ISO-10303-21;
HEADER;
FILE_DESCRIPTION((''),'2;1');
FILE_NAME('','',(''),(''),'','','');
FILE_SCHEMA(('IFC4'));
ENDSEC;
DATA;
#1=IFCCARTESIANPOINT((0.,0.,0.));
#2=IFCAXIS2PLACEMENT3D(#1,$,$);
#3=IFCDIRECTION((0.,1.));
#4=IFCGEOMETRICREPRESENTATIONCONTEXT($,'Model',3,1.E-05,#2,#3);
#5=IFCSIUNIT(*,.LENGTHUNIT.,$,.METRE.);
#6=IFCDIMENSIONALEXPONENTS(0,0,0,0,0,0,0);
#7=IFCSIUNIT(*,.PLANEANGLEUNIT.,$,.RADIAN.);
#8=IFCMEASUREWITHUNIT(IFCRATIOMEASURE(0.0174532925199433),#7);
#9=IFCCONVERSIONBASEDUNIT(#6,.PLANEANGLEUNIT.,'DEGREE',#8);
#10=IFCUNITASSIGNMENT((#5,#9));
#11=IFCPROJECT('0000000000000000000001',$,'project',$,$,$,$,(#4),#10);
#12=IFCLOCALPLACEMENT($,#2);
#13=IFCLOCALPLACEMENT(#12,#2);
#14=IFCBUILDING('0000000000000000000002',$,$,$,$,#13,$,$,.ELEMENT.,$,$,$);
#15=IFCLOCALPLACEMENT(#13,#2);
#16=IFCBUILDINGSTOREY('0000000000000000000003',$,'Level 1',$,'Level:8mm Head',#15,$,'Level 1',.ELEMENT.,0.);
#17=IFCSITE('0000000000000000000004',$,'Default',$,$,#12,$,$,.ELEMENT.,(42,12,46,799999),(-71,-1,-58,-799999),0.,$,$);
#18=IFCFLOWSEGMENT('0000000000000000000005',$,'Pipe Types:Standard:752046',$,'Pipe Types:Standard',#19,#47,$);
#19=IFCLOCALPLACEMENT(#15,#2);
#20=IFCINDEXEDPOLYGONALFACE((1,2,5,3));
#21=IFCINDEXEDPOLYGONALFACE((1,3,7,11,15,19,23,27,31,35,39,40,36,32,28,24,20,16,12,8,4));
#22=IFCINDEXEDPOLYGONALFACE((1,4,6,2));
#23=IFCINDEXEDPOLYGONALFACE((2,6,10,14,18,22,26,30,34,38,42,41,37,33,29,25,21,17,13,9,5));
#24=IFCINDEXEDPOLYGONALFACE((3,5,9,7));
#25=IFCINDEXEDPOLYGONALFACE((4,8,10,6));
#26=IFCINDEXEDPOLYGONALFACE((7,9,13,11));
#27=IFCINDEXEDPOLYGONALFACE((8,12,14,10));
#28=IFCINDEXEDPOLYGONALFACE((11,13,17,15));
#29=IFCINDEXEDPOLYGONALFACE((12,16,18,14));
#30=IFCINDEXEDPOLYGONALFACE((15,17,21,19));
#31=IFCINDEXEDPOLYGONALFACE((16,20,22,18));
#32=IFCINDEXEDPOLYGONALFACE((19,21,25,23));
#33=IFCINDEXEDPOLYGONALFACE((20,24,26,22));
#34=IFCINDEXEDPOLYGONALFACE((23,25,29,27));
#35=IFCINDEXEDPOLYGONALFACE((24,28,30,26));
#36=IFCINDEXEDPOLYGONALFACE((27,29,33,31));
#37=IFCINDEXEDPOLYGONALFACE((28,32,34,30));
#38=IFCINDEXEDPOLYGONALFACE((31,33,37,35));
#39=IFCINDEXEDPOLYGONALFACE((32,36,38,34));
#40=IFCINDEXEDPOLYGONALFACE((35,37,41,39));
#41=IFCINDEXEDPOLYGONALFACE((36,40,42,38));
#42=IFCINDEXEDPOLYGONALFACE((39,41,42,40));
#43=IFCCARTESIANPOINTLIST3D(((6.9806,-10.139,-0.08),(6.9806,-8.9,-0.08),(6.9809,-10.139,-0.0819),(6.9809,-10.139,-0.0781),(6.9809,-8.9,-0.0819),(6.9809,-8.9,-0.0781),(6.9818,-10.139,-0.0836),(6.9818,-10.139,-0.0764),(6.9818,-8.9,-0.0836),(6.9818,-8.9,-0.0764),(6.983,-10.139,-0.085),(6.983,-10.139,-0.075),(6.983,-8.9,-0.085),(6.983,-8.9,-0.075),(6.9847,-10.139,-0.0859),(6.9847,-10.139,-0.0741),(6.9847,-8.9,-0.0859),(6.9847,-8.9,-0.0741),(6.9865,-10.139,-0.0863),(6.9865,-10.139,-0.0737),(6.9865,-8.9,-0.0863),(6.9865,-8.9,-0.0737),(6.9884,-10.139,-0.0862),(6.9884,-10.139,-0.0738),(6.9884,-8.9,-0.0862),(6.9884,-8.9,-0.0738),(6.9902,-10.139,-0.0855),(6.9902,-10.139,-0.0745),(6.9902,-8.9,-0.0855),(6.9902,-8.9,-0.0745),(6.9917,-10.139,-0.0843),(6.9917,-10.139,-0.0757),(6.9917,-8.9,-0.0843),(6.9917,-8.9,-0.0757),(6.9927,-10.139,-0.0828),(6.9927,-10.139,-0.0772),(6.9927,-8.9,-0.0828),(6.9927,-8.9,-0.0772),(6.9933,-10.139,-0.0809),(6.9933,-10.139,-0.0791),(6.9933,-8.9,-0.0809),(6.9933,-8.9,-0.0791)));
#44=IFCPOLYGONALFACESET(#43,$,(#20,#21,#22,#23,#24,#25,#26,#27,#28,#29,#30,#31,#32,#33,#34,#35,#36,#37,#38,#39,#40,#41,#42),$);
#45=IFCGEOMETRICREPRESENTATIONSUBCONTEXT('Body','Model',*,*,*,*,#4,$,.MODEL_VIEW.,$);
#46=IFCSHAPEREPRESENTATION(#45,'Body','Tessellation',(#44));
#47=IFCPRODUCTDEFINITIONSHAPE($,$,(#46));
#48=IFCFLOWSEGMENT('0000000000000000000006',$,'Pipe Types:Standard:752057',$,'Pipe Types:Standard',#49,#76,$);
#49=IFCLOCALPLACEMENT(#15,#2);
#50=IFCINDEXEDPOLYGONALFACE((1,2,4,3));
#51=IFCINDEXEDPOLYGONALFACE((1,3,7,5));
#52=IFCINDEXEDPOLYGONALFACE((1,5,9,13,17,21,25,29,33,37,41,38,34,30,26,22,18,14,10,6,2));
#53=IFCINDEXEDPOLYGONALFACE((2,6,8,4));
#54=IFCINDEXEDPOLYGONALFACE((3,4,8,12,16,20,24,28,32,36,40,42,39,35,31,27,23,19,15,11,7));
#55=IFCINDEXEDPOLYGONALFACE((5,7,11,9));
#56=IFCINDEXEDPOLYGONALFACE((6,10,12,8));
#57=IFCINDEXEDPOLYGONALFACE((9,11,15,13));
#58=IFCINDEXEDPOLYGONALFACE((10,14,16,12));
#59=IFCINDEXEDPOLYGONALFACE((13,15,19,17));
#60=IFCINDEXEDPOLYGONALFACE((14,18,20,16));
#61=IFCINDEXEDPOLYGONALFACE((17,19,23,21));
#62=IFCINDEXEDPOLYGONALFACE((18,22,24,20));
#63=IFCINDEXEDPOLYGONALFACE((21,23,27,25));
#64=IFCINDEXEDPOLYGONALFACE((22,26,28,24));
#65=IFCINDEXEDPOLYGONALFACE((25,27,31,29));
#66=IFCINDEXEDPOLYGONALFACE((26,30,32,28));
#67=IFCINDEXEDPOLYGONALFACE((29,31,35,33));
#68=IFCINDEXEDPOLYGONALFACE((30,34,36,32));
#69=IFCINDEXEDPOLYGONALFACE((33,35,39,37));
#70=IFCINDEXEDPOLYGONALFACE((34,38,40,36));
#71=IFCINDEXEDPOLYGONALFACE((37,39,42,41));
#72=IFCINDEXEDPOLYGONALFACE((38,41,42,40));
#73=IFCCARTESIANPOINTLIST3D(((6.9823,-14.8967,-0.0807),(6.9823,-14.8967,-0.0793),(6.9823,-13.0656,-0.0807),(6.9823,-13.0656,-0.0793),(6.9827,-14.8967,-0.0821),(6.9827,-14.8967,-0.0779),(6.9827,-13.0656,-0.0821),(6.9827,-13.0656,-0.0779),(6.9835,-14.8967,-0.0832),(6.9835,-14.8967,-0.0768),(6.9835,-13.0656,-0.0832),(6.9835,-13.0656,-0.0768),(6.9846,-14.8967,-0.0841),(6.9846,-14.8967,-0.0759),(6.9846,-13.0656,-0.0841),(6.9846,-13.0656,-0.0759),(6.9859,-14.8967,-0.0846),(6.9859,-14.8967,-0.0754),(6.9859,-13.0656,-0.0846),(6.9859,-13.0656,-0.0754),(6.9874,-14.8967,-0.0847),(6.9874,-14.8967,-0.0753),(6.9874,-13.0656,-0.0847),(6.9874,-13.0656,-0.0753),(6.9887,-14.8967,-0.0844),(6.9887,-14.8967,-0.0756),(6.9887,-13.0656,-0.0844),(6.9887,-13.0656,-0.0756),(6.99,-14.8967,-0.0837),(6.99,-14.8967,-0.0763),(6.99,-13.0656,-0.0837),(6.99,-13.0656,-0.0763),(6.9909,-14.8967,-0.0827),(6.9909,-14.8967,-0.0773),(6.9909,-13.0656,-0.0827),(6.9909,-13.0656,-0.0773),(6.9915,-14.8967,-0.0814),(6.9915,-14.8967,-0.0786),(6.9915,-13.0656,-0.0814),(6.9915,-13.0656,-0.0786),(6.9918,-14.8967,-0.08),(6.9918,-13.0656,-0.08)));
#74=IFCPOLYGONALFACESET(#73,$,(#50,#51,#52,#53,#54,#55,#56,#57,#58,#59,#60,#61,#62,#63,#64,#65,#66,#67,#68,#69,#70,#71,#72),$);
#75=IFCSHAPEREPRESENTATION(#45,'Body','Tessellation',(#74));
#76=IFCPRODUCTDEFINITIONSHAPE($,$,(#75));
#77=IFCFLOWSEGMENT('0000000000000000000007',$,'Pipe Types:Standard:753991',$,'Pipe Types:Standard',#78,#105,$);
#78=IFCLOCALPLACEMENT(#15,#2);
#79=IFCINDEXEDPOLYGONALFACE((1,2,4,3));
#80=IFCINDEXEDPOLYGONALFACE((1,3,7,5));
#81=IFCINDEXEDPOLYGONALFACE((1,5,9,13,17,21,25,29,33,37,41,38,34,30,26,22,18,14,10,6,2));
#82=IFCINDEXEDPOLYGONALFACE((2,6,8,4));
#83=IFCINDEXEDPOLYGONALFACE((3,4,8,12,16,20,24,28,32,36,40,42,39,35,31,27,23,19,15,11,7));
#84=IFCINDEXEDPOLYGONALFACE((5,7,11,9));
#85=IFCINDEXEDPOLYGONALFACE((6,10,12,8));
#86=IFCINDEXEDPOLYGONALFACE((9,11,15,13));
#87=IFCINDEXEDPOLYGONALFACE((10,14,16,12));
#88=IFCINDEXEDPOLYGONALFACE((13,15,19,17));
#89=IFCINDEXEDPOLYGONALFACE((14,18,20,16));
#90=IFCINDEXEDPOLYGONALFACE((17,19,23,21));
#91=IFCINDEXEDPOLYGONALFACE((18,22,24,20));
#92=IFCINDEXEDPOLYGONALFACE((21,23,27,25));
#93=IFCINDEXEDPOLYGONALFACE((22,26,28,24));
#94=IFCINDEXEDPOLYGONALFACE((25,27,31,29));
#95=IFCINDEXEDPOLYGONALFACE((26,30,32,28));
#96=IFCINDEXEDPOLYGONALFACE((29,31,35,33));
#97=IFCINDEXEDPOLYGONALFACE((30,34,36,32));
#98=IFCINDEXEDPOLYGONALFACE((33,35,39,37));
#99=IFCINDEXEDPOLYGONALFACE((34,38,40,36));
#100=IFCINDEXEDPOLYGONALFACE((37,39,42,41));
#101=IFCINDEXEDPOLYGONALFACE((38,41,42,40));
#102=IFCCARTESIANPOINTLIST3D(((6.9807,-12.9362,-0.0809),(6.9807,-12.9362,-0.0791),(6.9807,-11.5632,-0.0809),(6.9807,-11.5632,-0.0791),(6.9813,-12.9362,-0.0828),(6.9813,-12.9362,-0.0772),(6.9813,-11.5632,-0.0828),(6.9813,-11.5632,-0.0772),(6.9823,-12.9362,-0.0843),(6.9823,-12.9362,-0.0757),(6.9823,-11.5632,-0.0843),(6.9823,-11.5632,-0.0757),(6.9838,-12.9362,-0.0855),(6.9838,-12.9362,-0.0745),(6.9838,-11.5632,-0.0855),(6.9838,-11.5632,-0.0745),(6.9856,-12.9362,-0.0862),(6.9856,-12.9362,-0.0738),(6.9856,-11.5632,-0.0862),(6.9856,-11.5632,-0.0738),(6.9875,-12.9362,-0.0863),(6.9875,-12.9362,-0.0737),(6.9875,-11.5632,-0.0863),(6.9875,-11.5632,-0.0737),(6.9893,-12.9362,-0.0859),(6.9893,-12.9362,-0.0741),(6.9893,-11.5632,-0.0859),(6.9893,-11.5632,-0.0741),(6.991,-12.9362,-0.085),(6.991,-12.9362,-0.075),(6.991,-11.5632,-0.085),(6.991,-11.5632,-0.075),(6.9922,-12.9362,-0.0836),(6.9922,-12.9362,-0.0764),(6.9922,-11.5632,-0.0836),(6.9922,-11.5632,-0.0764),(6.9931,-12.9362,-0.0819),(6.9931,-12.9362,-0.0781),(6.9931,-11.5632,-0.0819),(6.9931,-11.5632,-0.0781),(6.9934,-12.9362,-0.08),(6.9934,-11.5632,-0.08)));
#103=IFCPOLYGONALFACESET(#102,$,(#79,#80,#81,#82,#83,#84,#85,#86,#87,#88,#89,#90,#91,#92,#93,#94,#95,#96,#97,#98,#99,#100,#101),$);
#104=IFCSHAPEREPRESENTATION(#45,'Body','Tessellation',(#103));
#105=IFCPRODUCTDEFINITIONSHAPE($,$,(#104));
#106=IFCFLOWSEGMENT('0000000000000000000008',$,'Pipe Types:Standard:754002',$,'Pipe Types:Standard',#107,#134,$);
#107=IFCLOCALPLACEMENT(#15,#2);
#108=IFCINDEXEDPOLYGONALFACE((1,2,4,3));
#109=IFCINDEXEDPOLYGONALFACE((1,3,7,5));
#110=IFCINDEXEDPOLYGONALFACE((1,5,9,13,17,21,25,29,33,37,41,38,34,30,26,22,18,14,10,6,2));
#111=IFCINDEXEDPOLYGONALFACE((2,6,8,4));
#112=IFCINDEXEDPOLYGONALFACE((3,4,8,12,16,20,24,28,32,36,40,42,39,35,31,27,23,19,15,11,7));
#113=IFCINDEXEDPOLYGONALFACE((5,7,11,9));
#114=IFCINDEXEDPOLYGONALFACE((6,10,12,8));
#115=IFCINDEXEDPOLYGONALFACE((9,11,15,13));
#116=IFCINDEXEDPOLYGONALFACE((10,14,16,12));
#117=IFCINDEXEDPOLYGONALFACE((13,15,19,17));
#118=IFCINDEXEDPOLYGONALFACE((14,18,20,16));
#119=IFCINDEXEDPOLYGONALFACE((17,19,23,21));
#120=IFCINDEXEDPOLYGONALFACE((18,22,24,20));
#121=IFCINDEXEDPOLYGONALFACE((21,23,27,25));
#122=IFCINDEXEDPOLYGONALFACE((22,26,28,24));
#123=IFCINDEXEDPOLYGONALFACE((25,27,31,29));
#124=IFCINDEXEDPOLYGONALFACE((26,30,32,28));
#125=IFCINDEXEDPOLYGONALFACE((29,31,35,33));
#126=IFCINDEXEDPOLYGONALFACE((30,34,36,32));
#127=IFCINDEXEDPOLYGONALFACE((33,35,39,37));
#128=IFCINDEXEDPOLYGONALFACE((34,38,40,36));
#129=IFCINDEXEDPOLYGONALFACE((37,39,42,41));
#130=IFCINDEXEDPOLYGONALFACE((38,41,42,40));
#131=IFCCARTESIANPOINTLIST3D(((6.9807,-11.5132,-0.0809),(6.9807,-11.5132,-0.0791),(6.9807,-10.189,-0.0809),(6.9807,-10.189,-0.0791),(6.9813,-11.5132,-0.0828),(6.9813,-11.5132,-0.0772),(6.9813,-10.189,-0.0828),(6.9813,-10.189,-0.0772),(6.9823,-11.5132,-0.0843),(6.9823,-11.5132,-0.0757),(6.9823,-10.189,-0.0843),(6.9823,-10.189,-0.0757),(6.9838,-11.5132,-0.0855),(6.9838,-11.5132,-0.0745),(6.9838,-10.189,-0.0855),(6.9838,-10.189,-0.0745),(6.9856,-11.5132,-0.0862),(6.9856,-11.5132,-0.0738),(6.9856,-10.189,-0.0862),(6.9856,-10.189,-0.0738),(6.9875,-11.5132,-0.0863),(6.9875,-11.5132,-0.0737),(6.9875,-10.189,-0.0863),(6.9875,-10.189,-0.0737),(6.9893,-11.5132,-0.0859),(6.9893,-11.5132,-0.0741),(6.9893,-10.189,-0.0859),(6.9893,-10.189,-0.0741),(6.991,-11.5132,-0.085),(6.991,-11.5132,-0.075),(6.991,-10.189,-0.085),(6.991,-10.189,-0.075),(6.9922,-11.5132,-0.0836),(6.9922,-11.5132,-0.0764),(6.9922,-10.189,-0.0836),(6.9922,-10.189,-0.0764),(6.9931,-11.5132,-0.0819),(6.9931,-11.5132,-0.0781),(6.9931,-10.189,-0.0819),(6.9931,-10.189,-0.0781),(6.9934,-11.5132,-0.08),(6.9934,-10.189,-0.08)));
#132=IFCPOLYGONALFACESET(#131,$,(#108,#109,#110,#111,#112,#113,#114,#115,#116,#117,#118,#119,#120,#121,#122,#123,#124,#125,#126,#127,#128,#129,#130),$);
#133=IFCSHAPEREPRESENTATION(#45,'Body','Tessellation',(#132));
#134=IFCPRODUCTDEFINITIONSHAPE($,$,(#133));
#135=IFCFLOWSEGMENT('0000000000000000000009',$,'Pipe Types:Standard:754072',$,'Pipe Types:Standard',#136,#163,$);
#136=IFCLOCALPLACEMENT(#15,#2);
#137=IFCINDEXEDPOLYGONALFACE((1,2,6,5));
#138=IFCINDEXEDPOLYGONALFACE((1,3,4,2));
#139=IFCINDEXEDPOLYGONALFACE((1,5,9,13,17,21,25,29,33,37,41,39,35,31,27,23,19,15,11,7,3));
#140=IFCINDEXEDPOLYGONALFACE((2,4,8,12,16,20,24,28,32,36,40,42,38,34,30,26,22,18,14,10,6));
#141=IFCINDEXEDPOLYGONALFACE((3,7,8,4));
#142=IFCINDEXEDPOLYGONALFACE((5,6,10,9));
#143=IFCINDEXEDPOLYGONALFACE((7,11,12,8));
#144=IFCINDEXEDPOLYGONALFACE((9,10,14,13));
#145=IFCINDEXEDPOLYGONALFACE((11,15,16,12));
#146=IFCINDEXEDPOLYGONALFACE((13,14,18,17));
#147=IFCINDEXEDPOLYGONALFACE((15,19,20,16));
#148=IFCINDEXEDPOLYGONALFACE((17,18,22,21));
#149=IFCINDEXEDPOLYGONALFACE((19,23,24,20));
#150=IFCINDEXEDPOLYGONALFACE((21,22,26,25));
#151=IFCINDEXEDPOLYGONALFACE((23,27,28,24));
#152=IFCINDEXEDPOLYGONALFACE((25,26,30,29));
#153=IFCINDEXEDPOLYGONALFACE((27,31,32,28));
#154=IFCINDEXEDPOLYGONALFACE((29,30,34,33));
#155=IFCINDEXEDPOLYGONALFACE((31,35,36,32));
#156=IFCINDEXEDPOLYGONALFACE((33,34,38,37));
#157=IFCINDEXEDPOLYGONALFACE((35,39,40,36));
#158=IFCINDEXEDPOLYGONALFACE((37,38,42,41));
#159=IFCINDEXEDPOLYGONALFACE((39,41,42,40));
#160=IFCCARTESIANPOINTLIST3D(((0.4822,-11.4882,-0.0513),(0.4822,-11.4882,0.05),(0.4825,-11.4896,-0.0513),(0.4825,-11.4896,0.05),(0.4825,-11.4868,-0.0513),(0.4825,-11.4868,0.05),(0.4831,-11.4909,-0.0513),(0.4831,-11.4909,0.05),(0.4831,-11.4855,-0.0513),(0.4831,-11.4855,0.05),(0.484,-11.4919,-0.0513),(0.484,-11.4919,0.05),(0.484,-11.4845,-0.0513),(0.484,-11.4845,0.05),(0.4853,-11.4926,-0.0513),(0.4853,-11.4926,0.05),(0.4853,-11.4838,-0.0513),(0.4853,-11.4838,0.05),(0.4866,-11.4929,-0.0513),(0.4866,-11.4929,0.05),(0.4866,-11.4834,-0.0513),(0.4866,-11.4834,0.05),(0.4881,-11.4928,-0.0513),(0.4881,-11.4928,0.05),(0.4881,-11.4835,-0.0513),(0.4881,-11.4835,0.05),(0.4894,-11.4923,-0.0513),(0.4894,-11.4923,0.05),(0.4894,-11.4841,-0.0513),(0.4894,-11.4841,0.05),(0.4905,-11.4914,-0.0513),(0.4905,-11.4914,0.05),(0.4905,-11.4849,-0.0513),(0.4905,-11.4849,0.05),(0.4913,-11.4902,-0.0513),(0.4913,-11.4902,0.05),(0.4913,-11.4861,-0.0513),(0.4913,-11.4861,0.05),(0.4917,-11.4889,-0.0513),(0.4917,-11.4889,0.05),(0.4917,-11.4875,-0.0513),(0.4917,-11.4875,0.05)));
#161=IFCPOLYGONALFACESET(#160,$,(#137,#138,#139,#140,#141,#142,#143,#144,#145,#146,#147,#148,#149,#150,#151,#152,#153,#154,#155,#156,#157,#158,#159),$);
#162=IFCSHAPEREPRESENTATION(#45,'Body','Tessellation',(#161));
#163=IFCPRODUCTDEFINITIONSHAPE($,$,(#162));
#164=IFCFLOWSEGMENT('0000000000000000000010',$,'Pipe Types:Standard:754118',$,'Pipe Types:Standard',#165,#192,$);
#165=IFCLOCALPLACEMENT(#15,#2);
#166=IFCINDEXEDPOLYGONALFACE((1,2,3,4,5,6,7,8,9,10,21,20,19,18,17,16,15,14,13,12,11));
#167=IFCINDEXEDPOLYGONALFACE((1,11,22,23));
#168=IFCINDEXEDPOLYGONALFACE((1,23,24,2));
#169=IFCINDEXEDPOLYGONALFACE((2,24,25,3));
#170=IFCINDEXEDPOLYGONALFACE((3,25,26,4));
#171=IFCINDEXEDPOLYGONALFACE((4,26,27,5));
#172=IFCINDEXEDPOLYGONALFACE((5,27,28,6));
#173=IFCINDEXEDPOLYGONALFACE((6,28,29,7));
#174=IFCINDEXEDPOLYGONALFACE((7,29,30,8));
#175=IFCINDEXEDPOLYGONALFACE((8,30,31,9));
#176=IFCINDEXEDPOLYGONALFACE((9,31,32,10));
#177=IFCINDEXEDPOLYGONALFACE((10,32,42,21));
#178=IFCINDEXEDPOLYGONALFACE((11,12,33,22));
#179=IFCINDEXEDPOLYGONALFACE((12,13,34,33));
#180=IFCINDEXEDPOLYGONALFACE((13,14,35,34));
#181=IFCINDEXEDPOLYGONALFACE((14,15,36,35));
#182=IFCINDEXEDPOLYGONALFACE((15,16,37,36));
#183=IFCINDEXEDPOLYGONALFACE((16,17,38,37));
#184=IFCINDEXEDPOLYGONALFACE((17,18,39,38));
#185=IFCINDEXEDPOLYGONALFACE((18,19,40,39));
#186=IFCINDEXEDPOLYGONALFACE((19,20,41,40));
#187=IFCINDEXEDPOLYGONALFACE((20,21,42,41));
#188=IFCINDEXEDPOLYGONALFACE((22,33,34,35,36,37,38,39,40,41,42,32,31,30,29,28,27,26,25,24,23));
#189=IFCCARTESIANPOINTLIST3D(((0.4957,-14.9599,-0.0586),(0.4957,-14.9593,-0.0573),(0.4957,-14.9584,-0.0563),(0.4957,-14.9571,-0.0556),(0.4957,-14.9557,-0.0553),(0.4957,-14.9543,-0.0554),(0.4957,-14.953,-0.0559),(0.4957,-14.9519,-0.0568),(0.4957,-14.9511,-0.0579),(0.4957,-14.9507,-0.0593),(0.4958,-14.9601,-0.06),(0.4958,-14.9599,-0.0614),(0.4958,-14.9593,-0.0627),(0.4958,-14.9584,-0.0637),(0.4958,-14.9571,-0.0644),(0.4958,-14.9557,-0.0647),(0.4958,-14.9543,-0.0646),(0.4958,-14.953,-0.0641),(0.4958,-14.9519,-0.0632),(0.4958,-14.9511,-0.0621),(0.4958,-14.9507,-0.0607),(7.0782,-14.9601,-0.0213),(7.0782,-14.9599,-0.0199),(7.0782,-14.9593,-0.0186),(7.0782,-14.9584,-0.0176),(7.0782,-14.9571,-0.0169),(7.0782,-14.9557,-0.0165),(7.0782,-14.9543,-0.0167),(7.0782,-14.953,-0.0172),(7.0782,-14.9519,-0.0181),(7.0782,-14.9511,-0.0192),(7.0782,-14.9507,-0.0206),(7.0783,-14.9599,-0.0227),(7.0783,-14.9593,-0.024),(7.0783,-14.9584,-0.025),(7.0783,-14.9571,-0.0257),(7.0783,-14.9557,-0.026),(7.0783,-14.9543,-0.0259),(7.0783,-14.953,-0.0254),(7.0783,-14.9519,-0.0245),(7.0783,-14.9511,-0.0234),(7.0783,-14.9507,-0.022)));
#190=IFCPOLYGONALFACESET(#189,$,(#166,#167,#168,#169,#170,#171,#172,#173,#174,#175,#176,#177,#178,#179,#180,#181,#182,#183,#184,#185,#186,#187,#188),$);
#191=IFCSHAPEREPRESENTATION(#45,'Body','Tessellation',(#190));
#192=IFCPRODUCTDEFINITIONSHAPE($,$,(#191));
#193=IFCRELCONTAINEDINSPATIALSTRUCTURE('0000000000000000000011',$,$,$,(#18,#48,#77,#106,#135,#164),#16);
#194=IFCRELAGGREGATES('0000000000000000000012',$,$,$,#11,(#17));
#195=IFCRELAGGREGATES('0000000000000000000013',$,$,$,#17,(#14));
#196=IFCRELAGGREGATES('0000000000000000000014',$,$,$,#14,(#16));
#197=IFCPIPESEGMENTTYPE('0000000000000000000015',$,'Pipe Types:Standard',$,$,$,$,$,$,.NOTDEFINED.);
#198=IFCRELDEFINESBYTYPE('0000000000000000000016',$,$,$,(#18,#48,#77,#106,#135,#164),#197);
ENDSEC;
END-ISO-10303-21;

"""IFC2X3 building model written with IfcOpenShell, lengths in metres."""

from ifc_helpers import new_model, entity, si_unit, converted_unit, direction, frame, frame_2d, origin, origin_2d_with_axis, place, context, subcontext, project, spatial, circle, extrude, type_object, element, save


model = new_model("IFC2X3")

# Units and contexts
model_context = context("Model", 3, precision=1e-05, world=origin(), true_north=direction((0.0, 1.0)))
body_context = subcontext(model_context, "Body", "Model", "MODEL_VIEW")
ifc_project = project(units=[si_unit("LENGTHUNIT", "METRE"), converted_unit("PLANEANGLEUNIT", "DEGREE", entity("IfcRatioMeasure", 0.0174532925199433), si_unit("PLANEANGLEUNIT", "RADIAN"), dimensions=[0, 0, 0, 0, 0, 0, 0])], contexts=[model_context])

# Site, building, storey
site_placement = place(None, origin())
site = spatial("IfcSite", under=ifc_project, at=site_placement, Name="Default", CompositionType="ELEMENT", RefLatitude=(42, 12, 46, 799999), RefLongitude=(-71, -1, -58, -799999), RefElevation=0.0)
building_placement = place(site_placement, origin())
building = spatial("IfcBuilding", under=site, at=building_placement, CompositionType="ELEMENT")
storey_placement = place(building_placement, origin())
storey = spatial("IfcBuildingStorey", under=building, at=storey_placement, Name="Level 1", ObjectType="Level:8mm Head", LongName="Level 1", CompositionType="ELEMENT", Elevation=0.0)

# Flow segments
pipe_segment_type = type_object("IfcPipeSegmentType", Name="Pipe Types:Standard", PredefinedType="NOTDEFINED")
flow_segment_1_placement = place(storey_placement, origin())
element("IfcFlowSegment", 1, at=flow_segment_1_placement, inside=storey, type_object=pipe_segment_type, Name="Pipe Types:Standard:752046", ObjectType="Pipe Types:Standard", context=body_context, shape_type="SweptSolid", body=[
    extrude(circle(Radius=0.0063, at=frame_2d((0.0, 0.0), x_axis=(1.0, 0.0))), frame((6.987, -10.139, -0.08), z_axis=(0.0, 1.0, 0.0), x_axis=(-1.0, 0.0, 0.0)), (0.0, 0.0, 1.0), 1.239),
])
flow_segment_2_placement = place(storey_placement, origin())
element("IfcFlowSegment", 2, at=flow_segment_2_placement, inside=storey, type_object=pipe_segment_type, Name="Pipe Types:Standard:752057", ObjectType="Pipe Types:Standard", context=body_context, shape_type="SweptSolid", body=[
    extrude(circle(Radius=0.0048, at=frame_2d((0.0, 0.0), x_axis=(1.0, 0.0))), frame((6.987, -14.8967, -0.08), z_axis=(0.0, 1.0, 0.0), x_axis=(1.0, 0.0, 0.0)), (0.0, 0.0, 1.0), 1.8311),
])
flow_segment_3_placement = place(storey_placement, origin())
element("IfcFlowSegment", 3, at=flow_segment_3_placement, inside=storey, type_object=pipe_segment_type, Name="Pipe Types:Standard:753991", ObjectType="Pipe Types:Standard", context=body_context, shape_type="SweptSolid", body=[
    extrude(circle(Radius=0.0063, at=origin_2d_with_axis()), frame((6.987, -12.9362, -0.08), z_axis=(0.0, 1.0, 0.0), x_axis=(1.0, 0.0, 0.0)), (0.0, 0.0, 1.0), 1.373),
])
flow_segment_4_placement = place(storey_placement, origin())
element("IfcFlowSegment", 4, at=flow_segment_4_placement, inside=storey, type_object=pipe_segment_type, Name="Pipe Types:Standard:754002", ObjectType="Pipe Types:Standard", context=body_context, shape_type="SweptSolid", body=[
    extrude(circle(Radius=0.0063, at=origin_2d_with_axis()), frame((6.987, -11.5132, -0.08), z_axis=(0.0, 1.0, 0.0), x_axis=(1.0, 0.0, 0.0)), (0.0, 0.0, 1.0), 1.3242),
])
flow_segment_5_placement = place(storey_placement, origin())
element("IfcFlowSegment", 5, at=flow_segment_5_placement, inside=storey, type_object=pipe_segment_type, Name="Pipe Types:Standard:754072", ObjectType="Pipe Types:Standard", context=body_context, shape_type="SweptSolid", body=[
    extrude(circle(Radius=0.0048, at=origin_2d_with_axis()), frame((0.487, -11.4882, -0.0513), z_axis=(0.0, 0.0, 1.0), x_axis=(-1.0, 0.0, 0.0)), (0.0, 0.0, 1.0), 0.1013),
])
flow_segment_6_placement = place(storey_placement, origin())
element("IfcFlowSegment", 6, at=flow_segment_6_placement, inside=storey, type_object=pipe_segment_type, Name="Pipe Types:Standard:754118", ObjectType="Pipe Types:Standard", context=body_context, shape_type="SweptSolid", body=[
    extrude(circle(Radius=0.0048, at=origin_2d_with_axis()), frame((0.4958, -14.9554, -0.06), z_axis=(0.999983, 0.0, 0.00588), x_axis=(0.0, -1.0, 0.0)), (0.0, 0.0, 1.0), 6.5826),
])

save(model, "model.ifc")
